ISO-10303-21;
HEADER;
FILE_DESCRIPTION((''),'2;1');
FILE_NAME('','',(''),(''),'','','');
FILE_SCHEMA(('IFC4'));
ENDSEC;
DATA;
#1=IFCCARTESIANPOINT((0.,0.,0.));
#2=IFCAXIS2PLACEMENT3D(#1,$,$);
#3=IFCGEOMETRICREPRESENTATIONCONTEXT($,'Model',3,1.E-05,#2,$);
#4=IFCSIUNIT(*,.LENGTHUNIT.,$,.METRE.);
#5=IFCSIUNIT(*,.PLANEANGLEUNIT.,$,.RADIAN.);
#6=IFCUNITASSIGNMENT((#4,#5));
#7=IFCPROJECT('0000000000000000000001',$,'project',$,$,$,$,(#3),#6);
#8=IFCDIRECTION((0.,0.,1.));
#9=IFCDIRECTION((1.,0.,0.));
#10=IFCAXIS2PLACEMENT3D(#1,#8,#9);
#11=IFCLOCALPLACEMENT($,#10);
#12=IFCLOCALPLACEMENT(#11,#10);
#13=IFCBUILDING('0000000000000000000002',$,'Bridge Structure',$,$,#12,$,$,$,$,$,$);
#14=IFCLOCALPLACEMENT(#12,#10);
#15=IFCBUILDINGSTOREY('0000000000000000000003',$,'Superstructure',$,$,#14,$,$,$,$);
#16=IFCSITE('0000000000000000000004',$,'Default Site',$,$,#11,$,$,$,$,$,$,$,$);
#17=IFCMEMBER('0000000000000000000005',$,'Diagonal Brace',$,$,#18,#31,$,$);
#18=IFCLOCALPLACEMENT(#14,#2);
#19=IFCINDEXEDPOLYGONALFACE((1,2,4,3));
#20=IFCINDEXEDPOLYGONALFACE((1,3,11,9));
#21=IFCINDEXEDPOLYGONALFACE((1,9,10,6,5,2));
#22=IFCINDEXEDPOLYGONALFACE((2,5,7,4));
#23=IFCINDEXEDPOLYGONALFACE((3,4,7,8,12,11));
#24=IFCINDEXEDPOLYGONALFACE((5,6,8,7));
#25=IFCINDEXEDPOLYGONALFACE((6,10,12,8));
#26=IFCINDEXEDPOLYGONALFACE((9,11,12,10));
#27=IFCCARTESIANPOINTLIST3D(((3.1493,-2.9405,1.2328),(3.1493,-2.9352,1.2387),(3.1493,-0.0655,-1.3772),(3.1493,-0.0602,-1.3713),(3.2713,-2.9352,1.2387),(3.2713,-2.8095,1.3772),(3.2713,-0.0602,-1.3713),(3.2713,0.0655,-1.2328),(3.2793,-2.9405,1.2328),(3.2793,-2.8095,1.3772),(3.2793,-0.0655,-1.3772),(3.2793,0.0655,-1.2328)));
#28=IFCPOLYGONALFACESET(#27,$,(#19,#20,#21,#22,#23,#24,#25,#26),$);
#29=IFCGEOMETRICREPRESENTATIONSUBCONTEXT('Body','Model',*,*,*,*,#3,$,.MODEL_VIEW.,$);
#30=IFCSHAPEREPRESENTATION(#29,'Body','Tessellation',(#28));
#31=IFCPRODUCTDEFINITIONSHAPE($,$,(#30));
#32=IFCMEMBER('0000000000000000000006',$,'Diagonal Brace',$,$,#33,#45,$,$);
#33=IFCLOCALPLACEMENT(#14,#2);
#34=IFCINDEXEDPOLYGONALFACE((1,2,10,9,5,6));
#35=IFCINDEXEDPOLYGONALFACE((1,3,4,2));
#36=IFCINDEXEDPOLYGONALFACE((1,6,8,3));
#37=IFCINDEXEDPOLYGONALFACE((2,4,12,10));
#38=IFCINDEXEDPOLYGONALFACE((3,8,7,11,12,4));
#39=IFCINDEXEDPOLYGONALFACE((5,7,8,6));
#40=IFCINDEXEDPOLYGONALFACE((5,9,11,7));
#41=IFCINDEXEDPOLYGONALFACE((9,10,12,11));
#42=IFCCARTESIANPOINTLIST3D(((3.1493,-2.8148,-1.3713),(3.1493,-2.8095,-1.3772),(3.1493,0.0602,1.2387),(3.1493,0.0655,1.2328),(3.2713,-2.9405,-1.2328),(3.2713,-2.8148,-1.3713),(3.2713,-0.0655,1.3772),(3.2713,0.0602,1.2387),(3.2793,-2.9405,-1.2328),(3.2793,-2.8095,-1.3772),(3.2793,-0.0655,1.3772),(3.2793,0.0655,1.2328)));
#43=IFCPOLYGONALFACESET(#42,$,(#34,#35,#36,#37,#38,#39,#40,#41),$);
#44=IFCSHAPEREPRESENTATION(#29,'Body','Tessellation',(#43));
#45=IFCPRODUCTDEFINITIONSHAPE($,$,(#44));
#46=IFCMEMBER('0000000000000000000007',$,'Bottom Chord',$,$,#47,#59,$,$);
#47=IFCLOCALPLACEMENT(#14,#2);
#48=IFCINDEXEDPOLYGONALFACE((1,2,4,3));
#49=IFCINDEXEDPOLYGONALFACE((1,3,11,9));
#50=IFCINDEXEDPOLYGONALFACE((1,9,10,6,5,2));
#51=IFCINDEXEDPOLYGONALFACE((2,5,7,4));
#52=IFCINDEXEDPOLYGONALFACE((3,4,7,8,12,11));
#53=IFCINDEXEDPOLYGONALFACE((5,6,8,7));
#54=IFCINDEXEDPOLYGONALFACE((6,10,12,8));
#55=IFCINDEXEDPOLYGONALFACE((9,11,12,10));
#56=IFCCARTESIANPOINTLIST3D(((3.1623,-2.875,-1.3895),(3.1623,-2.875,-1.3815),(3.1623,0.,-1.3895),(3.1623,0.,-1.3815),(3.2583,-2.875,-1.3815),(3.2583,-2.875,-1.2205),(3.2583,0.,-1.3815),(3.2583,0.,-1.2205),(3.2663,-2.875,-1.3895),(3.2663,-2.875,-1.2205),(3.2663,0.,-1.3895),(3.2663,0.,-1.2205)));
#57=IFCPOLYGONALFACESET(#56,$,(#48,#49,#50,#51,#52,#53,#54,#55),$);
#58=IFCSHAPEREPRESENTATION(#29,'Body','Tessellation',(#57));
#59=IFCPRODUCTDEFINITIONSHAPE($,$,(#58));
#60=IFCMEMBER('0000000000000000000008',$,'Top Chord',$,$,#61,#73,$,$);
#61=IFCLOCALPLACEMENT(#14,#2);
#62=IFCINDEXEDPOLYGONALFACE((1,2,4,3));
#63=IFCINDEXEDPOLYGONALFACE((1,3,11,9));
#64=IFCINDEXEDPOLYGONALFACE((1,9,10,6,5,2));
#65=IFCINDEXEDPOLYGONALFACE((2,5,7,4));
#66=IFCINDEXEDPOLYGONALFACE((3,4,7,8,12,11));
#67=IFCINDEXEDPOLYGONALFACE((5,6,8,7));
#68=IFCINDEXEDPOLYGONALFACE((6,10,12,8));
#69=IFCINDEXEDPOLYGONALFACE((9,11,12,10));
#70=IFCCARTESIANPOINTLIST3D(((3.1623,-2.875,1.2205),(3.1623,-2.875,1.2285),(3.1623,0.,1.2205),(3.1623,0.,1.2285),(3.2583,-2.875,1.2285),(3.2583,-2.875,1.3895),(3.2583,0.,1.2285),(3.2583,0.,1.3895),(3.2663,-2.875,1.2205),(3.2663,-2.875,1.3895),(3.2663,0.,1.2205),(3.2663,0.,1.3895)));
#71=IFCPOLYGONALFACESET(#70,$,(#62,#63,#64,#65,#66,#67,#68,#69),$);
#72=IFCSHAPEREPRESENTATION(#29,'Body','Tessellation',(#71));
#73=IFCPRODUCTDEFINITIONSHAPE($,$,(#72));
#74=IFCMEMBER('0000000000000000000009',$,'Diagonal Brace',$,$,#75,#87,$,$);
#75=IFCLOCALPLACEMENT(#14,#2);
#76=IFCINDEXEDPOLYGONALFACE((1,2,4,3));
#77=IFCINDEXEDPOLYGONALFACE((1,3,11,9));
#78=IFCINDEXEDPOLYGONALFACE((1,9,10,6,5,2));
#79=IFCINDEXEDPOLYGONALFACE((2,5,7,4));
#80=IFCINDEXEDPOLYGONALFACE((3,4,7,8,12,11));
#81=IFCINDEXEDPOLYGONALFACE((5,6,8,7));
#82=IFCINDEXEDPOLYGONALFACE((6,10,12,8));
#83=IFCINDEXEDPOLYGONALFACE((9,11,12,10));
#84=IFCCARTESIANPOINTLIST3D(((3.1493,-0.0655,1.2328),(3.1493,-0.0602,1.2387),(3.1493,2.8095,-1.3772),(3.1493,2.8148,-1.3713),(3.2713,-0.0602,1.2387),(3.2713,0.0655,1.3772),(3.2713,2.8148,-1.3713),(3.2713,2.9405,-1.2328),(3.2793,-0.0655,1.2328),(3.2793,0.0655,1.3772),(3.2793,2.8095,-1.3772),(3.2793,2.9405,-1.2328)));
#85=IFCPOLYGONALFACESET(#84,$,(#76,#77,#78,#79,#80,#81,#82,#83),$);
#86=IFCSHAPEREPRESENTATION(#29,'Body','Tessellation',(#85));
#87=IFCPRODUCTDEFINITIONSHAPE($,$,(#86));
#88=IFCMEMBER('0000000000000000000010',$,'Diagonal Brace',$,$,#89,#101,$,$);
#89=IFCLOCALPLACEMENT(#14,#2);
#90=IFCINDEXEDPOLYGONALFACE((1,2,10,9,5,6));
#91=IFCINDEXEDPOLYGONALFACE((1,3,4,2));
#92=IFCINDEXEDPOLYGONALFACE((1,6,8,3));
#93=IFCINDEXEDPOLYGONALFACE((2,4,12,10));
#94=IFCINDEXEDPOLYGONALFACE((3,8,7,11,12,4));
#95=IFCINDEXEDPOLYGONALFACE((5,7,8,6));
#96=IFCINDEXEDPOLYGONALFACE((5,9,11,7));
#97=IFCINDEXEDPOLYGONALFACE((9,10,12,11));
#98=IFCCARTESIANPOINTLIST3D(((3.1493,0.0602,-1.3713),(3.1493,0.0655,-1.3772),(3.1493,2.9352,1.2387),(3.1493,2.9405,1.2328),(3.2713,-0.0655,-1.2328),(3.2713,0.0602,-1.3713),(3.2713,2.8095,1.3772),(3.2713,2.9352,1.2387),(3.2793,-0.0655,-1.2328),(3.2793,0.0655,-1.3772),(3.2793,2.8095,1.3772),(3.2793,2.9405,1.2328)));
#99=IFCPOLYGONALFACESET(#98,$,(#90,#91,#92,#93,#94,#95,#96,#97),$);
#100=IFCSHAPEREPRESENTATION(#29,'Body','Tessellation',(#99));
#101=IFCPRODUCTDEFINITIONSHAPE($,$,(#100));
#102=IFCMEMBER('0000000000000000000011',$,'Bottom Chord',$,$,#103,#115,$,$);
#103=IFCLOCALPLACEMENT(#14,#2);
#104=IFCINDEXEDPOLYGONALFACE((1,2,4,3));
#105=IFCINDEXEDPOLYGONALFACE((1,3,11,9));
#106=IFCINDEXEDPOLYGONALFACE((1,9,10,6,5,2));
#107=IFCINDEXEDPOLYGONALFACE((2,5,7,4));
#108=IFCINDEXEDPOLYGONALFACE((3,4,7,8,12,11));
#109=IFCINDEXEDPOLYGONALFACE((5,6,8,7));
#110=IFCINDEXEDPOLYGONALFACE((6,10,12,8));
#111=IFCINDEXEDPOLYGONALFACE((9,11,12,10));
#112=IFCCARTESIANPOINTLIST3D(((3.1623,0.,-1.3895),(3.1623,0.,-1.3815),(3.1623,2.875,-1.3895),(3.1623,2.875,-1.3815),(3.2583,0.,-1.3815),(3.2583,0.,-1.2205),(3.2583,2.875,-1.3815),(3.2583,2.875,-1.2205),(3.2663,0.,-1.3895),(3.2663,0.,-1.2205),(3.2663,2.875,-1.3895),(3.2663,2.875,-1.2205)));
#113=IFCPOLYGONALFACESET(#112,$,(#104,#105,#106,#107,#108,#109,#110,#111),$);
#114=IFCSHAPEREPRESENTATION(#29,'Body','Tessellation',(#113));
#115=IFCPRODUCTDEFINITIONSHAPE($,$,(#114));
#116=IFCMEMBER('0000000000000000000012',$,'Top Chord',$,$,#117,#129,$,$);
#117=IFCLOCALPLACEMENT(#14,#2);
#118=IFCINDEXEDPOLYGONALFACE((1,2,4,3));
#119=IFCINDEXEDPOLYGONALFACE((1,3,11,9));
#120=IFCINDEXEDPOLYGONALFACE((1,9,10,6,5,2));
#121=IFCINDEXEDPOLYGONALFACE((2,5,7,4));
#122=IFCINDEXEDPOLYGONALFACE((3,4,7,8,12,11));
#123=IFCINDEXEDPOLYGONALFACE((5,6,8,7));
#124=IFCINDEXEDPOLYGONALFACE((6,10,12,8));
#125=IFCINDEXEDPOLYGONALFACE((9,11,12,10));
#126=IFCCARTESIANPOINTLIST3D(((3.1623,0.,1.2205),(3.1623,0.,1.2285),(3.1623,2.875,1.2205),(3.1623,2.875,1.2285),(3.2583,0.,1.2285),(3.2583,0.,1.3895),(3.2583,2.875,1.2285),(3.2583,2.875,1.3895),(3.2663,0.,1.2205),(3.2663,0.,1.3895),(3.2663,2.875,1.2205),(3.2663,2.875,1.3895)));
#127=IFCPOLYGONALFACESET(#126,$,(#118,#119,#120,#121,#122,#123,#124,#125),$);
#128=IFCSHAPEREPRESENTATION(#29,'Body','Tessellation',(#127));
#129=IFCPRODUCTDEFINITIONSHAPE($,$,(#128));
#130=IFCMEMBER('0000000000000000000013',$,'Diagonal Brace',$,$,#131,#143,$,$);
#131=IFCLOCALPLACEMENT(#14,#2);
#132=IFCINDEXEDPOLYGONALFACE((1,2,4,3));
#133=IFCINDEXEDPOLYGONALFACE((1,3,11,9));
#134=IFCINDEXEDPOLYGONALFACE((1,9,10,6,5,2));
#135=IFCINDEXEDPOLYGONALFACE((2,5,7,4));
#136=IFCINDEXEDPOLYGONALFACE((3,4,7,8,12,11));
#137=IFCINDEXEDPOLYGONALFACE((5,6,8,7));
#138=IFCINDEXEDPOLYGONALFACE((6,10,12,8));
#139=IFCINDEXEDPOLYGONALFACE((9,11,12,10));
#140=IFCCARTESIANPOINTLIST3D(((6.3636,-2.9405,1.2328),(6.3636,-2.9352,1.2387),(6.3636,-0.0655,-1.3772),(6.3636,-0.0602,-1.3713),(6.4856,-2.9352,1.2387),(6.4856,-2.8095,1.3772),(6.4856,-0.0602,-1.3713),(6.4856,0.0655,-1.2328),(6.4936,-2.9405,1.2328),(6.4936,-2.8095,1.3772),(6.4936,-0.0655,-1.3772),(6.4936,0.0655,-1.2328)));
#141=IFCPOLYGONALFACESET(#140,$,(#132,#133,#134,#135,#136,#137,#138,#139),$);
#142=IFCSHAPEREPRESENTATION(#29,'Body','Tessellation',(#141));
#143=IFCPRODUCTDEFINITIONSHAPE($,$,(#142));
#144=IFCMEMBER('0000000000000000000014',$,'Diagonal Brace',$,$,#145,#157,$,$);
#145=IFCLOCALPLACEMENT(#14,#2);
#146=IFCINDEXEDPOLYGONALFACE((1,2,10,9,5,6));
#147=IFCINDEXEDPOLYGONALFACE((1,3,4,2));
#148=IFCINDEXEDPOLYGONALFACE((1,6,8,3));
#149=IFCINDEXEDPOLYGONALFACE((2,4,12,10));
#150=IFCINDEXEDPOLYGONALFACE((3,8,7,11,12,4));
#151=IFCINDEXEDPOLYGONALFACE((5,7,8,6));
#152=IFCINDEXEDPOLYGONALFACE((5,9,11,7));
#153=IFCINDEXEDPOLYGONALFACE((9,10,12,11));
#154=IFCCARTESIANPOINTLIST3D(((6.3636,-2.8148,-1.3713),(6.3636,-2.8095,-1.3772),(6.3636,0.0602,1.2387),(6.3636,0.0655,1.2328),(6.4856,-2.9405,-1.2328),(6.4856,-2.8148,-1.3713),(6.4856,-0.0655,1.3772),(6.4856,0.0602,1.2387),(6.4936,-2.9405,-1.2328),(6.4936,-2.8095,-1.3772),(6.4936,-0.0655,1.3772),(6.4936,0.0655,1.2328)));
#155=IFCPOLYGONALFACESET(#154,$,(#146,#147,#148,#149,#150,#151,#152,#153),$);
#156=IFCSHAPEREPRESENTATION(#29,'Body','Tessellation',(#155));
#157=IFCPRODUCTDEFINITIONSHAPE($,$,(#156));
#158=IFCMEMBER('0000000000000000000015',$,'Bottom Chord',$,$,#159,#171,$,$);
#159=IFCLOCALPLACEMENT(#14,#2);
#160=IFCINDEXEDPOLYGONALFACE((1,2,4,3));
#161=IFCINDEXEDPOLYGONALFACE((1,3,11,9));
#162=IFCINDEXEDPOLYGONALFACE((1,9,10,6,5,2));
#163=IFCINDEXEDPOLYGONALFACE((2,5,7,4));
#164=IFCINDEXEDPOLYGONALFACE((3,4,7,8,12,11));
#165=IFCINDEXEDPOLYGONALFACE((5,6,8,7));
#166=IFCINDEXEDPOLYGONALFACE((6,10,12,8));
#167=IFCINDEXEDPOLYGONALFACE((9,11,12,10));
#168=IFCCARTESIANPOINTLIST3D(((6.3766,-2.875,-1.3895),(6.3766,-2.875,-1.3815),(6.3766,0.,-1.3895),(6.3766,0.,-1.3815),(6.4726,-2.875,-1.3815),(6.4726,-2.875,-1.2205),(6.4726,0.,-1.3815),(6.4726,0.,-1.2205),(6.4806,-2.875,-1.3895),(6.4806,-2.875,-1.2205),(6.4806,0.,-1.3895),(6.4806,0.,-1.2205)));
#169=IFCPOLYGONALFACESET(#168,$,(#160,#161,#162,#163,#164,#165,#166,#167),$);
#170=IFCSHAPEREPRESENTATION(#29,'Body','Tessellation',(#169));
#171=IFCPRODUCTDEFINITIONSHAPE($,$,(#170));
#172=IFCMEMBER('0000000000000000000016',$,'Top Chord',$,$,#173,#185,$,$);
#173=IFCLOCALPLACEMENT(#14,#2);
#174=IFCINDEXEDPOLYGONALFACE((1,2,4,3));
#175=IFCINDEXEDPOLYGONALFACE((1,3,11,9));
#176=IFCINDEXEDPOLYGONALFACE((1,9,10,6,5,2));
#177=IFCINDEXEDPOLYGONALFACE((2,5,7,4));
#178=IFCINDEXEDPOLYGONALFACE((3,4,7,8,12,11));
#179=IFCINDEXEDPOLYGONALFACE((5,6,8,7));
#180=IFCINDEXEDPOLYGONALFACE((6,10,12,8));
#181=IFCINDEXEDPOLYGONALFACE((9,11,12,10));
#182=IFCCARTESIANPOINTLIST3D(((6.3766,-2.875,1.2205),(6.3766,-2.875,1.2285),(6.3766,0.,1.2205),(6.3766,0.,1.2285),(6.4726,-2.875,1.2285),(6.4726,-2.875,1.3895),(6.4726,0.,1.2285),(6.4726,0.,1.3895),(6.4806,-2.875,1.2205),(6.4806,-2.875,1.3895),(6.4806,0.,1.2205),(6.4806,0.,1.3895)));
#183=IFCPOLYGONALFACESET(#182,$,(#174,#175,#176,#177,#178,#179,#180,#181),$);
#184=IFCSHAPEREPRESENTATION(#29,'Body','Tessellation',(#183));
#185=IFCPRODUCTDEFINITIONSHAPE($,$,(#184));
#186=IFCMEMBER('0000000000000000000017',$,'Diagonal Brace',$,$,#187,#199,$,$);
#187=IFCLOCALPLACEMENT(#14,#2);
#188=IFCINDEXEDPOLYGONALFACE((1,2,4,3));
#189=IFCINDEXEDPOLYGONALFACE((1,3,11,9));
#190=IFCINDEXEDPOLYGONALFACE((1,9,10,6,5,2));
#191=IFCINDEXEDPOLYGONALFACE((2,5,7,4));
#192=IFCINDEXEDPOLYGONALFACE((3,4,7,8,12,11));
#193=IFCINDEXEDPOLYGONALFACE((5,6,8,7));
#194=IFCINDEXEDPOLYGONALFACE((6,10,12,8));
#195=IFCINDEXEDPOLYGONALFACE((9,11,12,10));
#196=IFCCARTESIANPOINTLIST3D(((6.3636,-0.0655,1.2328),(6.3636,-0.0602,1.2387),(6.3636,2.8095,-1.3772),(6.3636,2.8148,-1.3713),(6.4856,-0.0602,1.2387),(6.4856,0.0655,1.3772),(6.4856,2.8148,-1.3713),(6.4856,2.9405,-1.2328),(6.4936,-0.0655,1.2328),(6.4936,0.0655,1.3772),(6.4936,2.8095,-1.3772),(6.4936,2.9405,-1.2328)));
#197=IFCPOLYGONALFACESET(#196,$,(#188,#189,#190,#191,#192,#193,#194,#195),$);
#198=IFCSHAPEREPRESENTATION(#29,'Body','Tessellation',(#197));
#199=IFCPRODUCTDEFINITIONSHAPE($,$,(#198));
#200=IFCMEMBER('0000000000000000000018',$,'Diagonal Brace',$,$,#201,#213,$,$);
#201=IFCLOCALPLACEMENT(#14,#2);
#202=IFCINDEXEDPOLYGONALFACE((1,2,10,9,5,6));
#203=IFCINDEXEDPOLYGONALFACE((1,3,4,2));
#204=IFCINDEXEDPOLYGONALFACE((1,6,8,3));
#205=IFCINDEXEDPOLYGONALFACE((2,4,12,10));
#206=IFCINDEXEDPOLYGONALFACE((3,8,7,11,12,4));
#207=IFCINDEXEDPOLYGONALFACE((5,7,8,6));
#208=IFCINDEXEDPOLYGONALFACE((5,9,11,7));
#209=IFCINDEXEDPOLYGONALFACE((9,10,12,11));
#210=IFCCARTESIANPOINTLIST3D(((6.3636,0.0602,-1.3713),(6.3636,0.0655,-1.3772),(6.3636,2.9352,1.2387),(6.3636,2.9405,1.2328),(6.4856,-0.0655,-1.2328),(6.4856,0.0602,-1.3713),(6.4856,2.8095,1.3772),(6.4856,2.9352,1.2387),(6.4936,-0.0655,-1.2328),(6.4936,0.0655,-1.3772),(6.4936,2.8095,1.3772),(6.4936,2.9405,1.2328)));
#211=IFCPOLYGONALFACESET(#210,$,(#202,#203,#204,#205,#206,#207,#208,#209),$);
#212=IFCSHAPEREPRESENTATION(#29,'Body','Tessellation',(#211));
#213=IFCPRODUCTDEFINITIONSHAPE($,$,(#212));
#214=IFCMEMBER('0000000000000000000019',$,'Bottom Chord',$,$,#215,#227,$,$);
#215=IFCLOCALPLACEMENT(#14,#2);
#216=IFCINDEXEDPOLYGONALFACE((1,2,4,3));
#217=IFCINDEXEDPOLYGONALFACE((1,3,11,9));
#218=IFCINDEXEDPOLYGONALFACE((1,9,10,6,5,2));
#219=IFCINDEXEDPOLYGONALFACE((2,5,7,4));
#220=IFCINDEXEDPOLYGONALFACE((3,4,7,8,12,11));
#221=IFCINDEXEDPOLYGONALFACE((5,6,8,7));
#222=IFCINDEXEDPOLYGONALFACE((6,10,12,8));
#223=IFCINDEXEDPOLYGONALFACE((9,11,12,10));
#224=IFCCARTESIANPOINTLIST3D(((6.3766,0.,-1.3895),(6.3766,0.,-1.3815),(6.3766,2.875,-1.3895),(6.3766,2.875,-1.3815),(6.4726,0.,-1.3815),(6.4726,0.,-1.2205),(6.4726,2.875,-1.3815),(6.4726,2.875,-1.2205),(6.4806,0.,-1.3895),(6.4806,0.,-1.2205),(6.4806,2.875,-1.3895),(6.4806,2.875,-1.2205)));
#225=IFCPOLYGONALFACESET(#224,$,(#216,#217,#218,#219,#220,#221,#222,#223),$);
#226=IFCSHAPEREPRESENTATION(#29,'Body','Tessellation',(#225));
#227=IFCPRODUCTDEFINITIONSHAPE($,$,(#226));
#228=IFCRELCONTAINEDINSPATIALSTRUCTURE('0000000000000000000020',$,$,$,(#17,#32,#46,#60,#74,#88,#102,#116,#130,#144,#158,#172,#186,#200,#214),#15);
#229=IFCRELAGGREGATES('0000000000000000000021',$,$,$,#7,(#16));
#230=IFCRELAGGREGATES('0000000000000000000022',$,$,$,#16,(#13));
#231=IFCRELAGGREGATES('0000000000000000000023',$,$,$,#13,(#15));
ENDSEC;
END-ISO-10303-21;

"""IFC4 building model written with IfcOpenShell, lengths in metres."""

from ifc_helpers import new_model, si_unit, frame, origin, origin_with_axes, origin_2d_with_axis, place, context, subcontext, project, spatial, l_section, extrude, element, save


model = new_model("IFC4")

# Units and contexts
model_context = context("Model", 3, precision=1e-05, world=origin())
body_context = subcontext(model_context, "Body", "Model", "MODEL_VIEW")
ifc_project = project(units=[si_unit("LENGTHUNIT", "METRE"), si_unit("PLANEANGLEUNIT", "RADIAN")], contexts=[model_context])

# Site, building, storey
site_placement = place(None, origin_with_axes())
site = spatial("IfcSite", under=ifc_project, at=site_placement, Name="Default Site")
building_placement = place(site_placement, origin_with_axes())
building = spatial("IfcBuilding", under=site, at=building_placement, Name="Bridge Structure")
storey_placement = place(building_placement, origin_with_axes())
storey = spatial("IfcBuildingStorey", under=building, at=storey_placement, Name="Superstructure")

# Members
for number, where, z_axis, x_axis, name in (
    (1, (3.2143, -2.875, 1.305), (0.0, 0.740406, -0.67216), (-1.0, 0.0, 0.0), "Diagonal Brace"),
    (2, (3.2143, -2.875, -1.305), (0.0, 0.740406, 0.67216), (-1.0, 0.0, 0.0), "Diagonal Brace"),
):
    element("IfcMember", number, at=place(storey_placement, frame(where, z_axis=z_axis, x_axis=x_axis)), inside=storey, Name=name, context=body_context, shape_type="SweptSolid", body=[
        extrude(l_section(Depth=0.195, Width=0.13, Thickness=0.008, at=origin_2d_with_axis()), origin_with_axes(), (0.0, 0.0, 1.0), 3.883),
    ])
for number, where, z_axis, x_axis, name in (
    (3, (3.2143, -2.875, -1.305), (0.0, 1.0, 0.0), (-1.0, 0.0, 0.0), "Bottom Chord"),
    (4, (3.2143, -2.875, 1.305), (0.0, 1.0, 0.0), (-1.0, 0.0, 0.0), "Top Chord"),
):
    element("IfcMember", number, at=place(storey_placement, frame(where, z_axis=z_axis, x_axis=x_axis)), inside=storey, Name=name, context=body_context, shape_type="SweptSolid", body=[
        extrude(l_section(Depth=0.169, Width=0.104, Thickness=0.008, at=origin_2d_with_axis()), origin_with_axes(), (0.0, 0.0, 1.0), 2.875),
    ])
for number, where, z_axis, x_axis, name in (
    (5, (3.2143, 0.0, 1.305), (0.0, 0.740406, -0.67216), (-1.0, 0.0, 0.0), "Diagonal Brace"),
    (6, (3.2143, 0.0, -1.305), (0.0, 0.740406, 0.67216), (-1.0, 0.0, 0.0), "Diagonal Brace"),
):
    element("IfcMember", number, at=place(storey_placement, frame(where, z_axis=z_axis, x_axis=x_axis)), inside=storey, Name=name, context=body_context, shape_type="SweptSolid", body=[
        extrude(l_section(Depth=0.195, Width=0.13, Thickness=0.008, at=origin_2d_with_axis()), origin_with_axes(), (0.0, 0.0, 1.0), 3.883),
    ])
for number, where, z_axis, x_axis, name in (
    (7, (3.2143, 0.0, -1.305), (0.0, 1.0, 0.0), (-1.0, 0.0, 0.0), "Bottom Chord"),
    (8, (3.2143, 0.0, 1.305), (0.0, 1.0, 0.0), (-1.0, 0.0, 0.0), "Top Chord"),
):
    element("IfcMember", number, at=place(storey_placement, frame(where, z_axis=z_axis, x_axis=x_axis)), inside=storey, Name=name, context=body_context, shape_type="SweptSolid", body=[
        extrude(l_section(Depth=0.169, Width=0.104, Thickness=0.008, at=origin_2d_with_axis()), origin_with_axes(), (0.0, 0.0, 1.0), 2.875),
    ])
for number, where, z_axis, x_axis, name in (
    (9, (6.4286, -2.875, 1.305), (0.0, 0.740406, -0.67216), (-1.0, 0.0, 0.0), "Diagonal Brace"),
    (10, (6.4286, -2.875, -1.305), (0.0, 0.740406, 0.67216), (-1.0, 0.0, 0.0), "Diagonal Brace"),
):
    element("IfcMember", number, at=place(storey_placement, frame(where, z_axis=z_axis, x_axis=x_axis)), inside=storey, Name=name, context=body_context, shape_type="SweptSolid", body=[
        extrude(l_section(Depth=0.195, Width=0.13, Thickness=0.008, at=origin_2d_with_axis()), origin_with_axes(), (0.0, 0.0, 1.0), 3.883),
    ])
for number, where, z_axis, x_axis, name in (
    (11, (6.4286, -2.875, -1.305), (0.0, 1.0, 0.0), (-1.0, 0.0, 0.0), "Bottom Chord"),
    (12, (6.4286, -2.875, 1.305), (0.0, 1.0, 0.0), (-1.0, 0.0, 0.0), "Top Chord"),
):
    element("IfcMember", number, at=place(storey_placement, frame(where, z_axis=z_axis, x_axis=x_axis)), inside=storey, Name=name, context=body_context, shape_type="SweptSolid", body=[
        extrude(l_section(Depth=0.169, Width=0.104, Thickness=0.008, at=origin_2d_with_axis()), origin_with_axes(), (0.0, 0.0, 1.0), 2.875),
    ])
for number, where, z_axis, x_axis, name in (
    (13, (6.4286, 0.0, 1.305), (0.0, 0.740406, -0.67216), (-1.0, 0.0, 0.0), "Diagonal Brace"),
    (14, (6.4286, 0.0, -1.305), (0.0, 0.740406, 0.67216), (-1.0, 0.0, 0.0), "Diagonal Brace"),
):
    element("IfcMember", number, at=place(storey_placement, frame(where, z_axis=z_axis, x_axis=x_axis)), inside=storey, Name=name, context=body_context, shape_type="SweptSolid", body=[
        extrude(l_section(Depth=0.195, Width=0.13, Thickness=0.008, at=origin_2d_with_axis()), origin_with_axes(), (0.0, 0.0, 1.0), 3.883),
    ])
for number, where, z_axis, x_axis, name in (
    (15, (6.4286, 0.0, -1.305), (0.0, 1.0, 0.0), (-1.0, 0.0, 0.0), "Bottom Chord"),
):
    element("IfcMember", number, at=place(storey_placement, frame(where, z_axis=z_axis, x_axis=x_axis)), inside=storey, Name=name, context=body_context, shape_type="SweptSolid", body=[
        extrude(l_section(Depth=0.169, Width=0.104, Thickness=0.008, at=origin_2d_with_axis()), origin_with_axes(), (0.0, 0.0, 1.0), 2.875),
    ])

save(model, "model.ifc")
